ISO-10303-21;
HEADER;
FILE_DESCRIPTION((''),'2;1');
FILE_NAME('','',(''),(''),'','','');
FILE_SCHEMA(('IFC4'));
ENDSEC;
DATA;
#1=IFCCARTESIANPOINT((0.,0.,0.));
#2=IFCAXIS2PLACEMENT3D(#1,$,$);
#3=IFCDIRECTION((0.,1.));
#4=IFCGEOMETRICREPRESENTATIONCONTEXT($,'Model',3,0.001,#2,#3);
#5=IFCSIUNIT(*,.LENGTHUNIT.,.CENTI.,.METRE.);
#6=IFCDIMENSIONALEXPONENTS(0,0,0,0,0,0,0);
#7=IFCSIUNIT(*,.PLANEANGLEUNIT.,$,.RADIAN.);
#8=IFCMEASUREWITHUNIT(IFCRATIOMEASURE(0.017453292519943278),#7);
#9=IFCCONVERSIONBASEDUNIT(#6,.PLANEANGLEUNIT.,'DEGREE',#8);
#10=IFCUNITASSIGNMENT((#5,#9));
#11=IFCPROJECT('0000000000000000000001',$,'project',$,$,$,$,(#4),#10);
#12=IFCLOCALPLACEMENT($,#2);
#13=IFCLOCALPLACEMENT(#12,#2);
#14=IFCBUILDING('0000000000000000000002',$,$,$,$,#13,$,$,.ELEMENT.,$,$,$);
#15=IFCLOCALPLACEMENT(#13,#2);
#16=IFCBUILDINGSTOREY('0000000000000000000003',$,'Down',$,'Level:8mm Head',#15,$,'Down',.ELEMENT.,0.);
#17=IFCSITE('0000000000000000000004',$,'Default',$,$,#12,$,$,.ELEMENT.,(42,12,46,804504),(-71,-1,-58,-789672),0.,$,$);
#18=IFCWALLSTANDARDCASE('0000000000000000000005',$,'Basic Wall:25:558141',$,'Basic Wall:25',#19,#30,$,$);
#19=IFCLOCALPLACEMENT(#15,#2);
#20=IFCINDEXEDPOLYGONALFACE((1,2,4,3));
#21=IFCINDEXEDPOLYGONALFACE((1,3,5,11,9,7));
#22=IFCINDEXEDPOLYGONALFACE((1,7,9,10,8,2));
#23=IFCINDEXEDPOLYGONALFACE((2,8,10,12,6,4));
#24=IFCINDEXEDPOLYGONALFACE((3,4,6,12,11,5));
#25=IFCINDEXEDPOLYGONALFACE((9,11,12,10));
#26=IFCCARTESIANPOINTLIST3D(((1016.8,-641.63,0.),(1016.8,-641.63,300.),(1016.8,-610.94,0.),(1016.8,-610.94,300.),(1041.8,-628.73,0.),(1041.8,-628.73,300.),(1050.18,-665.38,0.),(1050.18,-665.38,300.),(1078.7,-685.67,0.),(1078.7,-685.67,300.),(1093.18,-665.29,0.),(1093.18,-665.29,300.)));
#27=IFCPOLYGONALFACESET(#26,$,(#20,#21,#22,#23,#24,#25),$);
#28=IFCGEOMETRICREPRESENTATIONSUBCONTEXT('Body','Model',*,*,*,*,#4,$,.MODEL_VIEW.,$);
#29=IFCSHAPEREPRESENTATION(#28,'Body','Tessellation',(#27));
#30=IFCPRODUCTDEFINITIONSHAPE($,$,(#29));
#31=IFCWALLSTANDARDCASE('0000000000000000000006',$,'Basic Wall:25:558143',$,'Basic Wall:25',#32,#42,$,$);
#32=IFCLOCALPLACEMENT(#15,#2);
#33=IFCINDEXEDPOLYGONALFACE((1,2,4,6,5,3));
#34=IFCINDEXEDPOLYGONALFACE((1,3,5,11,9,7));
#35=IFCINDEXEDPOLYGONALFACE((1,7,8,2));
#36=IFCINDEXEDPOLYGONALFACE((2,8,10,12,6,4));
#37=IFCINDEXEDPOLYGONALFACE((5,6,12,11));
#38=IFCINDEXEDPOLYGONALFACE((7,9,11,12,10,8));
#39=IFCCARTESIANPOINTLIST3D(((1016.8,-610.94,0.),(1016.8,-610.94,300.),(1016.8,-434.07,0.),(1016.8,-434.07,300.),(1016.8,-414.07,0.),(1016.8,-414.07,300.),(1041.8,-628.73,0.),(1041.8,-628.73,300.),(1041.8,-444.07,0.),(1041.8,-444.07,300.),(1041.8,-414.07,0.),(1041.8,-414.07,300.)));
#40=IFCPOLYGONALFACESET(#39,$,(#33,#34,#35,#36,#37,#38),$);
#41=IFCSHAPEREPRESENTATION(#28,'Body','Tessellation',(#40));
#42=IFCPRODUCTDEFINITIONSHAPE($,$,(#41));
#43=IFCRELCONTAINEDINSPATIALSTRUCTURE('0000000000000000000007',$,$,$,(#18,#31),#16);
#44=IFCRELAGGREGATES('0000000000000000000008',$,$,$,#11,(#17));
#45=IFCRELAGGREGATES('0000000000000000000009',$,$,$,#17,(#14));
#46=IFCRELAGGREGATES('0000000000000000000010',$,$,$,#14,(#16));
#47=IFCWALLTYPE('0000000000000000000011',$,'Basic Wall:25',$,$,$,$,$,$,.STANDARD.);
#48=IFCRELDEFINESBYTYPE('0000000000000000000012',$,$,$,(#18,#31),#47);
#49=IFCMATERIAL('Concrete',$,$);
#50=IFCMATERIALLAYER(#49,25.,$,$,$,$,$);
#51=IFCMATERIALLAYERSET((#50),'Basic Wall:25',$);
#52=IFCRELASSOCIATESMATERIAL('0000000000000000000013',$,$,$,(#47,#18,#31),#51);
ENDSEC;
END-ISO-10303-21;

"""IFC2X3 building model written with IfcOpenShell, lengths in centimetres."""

from ifc_helpers import new_model, entity, si_unit, converted_unit, direction, frame, origin, place, context, subcontext, project, spatial, polyline, outline, extrude, material, layer, layer_set, layer_usage, type_object, element, save


model = new_model("IFC2X3")

# Units and contexts
model_context = context("Model", 3, precision=0.001, world=origin(), true_north=direction((0.0, 1.0)))
body_context = subcontext(model_context, "Body", "Model", "MODEL_VIEW")
ifc_project = project(units=[si_unit("LENGTHUNIT", "METRE", prefix="CENTI"), converted_unit("PLANEANGLEUNIT", "DEGREE", entity("IfcRatioMeasure", 0.017453292519943278), si_unit("PLANEANGLEUNIT", "RADIAN"), dimensions=[0, 0, 0, 0, 0, 0, 0])], contexts=[model_context])

# Site, building, storey
site_placement = place(None, origin())
site = spatial("IfcSite", under=ifc_project, at=site_placement, Name="Default", CompositionType="ELEMENT", RefLatitude=(42, 12, 46, 804504), RefLongitude=(-71, -1, -58, -789672), RefElevation=0.0)
building_placement = place(site_placement, origin())
building = spatial("IfcBuilding", under=site, at=building_placement, CompositionType="ELEMENT")
storey_placement = place(building_placement, origin())
storey = spatial("IfcBuildingStorey", under=building, at=storey_placement, Name="Down", ObjectType="Level:8mm Head", LongName="Down", CompositionType="ELEMENT", Elevation=0.0)

# Walls
ifc_material = material(Name="Concrete")
ifc_layer_1 = layer(ifc_material, 25.0)
ifc_layer_set_1 = layer_set([ifc_layer_1], Name="Basic Wall:25")
wall_type_1 = type_object("IfcWallType", Name="Basic Wall:25", PredefinedType="STANDARD", material=ifc_layer_set_1)
ifc_layer_usage_1 = layer_usage(ifc_layer_set_1, "AXIS2", "POSITIVE", -12.5)
wall_1_placement = place(storey_placement, frame((1085.94, -675.48, 0.0), z_axis=(0.0, 0.0, 1.0), x_axis=(-0.814791, 0.579755, 0.0)))
element("IfcWallStandardCase", 1, at=wall_1_placement, inside=storey, type_object=wall_type_1, material=ifc_layer_usage_1, Name="Basic Wall:25:558141", ObjectType="Basic Wall:25", context=body_context, shape_type="SweptSolid", body=[
    extrude(outline(polyline([(93.76, -12.5), (75.97, 12.5), (35.0, 12.5), (0.0, 12.5), (0.02, -12.5), (63.07, -12.5), (93.76, -12.5)])), origin(), (0.0, 0.0, 1.0), 300.0),
])
ifc_layer_usage_2 = layer_usage(ifc_layer_set_1, "AXIS2", "POSITIVE", -12.5)
wall_2_placement = place(storey_placement, frame((1029.3, -628.73, 0.0), z_axis=(0.0, 0.0, 1.0), x_axis=(0.0, 1.0, 0.0)))
element("IfcWallStandardCase", 2, at=wall_2_placement, inside=storey, type_object=wall_type_1, material=ifc_layer_usage_2, Name="Basic Wall:25:558143", ObjectType="Basic Wall:25", context=body_context, shape_type="SweptSolid", body=[
    extrude(outline(polyline([(214.66, -12.5), (214.66, 12.5), (194.66, 12.5), (17.79, 12.5), (0.0, -12.5), (184.66, -12.5), (214.66, -12.5)])), origin(), (0.0, 0.0, 1.0), 300.0),
])

save(model, "model.ifc")
